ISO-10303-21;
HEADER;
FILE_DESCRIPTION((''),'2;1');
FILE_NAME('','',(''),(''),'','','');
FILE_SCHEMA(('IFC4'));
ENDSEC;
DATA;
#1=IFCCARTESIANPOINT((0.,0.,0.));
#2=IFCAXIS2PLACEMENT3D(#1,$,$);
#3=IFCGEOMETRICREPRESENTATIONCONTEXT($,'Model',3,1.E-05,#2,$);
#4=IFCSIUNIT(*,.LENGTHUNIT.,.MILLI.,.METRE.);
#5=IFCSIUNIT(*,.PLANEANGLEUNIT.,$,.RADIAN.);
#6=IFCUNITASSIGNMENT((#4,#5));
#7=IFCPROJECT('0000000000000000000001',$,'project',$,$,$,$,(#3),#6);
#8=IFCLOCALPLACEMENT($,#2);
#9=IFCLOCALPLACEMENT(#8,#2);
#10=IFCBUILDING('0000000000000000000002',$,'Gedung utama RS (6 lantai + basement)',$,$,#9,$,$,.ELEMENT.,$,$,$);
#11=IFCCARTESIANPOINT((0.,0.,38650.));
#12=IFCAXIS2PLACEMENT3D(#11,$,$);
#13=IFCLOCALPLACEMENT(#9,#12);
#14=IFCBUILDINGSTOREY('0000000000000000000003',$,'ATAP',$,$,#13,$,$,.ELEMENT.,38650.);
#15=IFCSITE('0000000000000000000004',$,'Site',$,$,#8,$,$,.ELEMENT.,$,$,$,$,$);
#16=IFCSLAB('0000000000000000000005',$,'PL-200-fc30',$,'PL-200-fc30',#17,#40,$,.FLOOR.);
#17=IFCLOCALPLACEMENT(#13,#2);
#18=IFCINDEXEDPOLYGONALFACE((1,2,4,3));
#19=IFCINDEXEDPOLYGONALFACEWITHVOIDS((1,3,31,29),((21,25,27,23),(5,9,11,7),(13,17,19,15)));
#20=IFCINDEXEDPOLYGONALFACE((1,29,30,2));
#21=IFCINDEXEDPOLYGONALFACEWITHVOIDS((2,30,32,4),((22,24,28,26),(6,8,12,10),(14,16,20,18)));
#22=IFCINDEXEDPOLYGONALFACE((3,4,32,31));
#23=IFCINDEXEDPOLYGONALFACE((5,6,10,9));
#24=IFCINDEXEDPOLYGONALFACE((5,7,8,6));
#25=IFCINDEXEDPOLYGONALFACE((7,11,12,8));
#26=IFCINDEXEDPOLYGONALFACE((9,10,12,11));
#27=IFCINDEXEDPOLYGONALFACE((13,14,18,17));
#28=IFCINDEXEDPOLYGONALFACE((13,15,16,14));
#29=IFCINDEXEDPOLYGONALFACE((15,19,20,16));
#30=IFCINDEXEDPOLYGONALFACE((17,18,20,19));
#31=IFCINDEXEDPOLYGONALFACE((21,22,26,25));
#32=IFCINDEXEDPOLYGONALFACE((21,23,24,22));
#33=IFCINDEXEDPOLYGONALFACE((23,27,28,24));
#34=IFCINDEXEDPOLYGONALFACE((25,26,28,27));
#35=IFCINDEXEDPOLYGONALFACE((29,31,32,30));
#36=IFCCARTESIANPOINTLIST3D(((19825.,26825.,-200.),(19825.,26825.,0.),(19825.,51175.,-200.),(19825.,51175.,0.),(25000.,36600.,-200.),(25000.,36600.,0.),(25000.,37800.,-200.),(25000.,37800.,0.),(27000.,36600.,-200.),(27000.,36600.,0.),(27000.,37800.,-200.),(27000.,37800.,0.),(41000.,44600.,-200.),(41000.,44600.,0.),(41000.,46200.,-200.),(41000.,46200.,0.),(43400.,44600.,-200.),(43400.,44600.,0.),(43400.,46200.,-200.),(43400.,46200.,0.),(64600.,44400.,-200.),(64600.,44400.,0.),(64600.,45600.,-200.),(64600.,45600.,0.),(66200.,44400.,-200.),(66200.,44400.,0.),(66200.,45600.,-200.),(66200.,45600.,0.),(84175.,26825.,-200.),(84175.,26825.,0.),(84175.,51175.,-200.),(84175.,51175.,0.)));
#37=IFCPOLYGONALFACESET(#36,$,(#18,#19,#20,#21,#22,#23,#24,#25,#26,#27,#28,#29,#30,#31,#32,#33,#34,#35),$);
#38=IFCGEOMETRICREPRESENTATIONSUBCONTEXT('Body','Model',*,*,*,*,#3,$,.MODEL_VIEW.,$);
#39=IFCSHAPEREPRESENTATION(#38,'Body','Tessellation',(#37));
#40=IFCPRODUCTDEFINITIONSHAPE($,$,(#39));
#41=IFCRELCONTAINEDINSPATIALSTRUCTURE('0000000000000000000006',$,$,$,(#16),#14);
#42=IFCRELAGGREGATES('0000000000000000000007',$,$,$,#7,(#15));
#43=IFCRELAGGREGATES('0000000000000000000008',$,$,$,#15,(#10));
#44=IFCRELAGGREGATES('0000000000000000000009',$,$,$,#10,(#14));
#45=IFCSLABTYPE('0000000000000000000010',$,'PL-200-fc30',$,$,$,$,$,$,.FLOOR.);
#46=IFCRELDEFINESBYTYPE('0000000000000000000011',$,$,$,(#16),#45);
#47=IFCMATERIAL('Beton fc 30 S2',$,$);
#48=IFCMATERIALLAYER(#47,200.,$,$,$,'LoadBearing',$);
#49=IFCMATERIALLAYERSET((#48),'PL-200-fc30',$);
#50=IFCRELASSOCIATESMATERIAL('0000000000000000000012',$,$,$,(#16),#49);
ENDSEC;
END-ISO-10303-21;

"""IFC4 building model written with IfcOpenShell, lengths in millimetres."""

from ifc_helpers import new_model, si_unit, frame, origin, place, context, subcontext, project, spatial, polyline, outline, extrude, material, layer, layer_set, layer_usage, type_object, element, save


model = new_model("IFC4")

# Units and contexts
model_context = context("Model", 3, precision=1e-05, world=origin())
body_context = subcontext(model_context, "Body", "Model", "MODEL_VIEW")
ifc_project = project(units=[si_unit("LENGTHUNIT", "METRE", prefix="MILLI"), si_unit("PLANEANGLEUNIT", "RADIAN")], contexts=[model_context])

# Site, building, storey
site_placement = place(None, origin())
site = spatial("IfcSite", under=ifc_project, at=site_placement, Name="Site", CompositionType="ELEMENT")
building_placement = place(site_placement, origin())
building = spatial("IfcBuilding", under=site, at=building_placement, Name="Gedung utama RS (6 lantai + basement)", CompositionType="ELEMENT")
storey_placement = place(building_placement, frame((0.0, 0.0, 38650.0)))
storey = spatial("IfcBuildingStorey", under=building, at=storey_placement, Name="ATAP", CompositionType="ELEMENT", Elevation=38650.0)

# Shared definitions
ifc_material = material(Name="Beton fc 30 S2")

# Slab, openings
ifc_layer = layer(ifc_material, 200.0, Category="LoadBearing")
ifc_layer_set = layer_set([ifc_layer], Name="PL-200-fc30")
ifc_layer_usage = layer_usage(ifc_layer_set, "AXIS3", "NEGATIVE", 0.0)
slab_type = type_object("IfcSlabType", Name="PL-200-fc30", PredefinedType="FLOOR")
slab_placement = place(storey_placement, origin())
slab = element("IfcSlab", 1, at=slab_placement, inside=storey, type_object=slab_type, material=ifc_layer_usage, Name="PL-200-fc30", ObjectType="PL-200-fc30", PredefinedType="FLOOR", context=body_context, shape_type="SweptSolid", body=[
    extrude(outline(polyline([(84175.0, 51175.0), (19825.0, 51175.0), (19825.0, 26825.0), (84175.0, 26825.0), (84175.0, 51175.0)])), frame((0.0, 0.0, -200.0)), (0.0, 0.0, 1.0), 200.0),
])
opening_1_placement = place(slab_placement, frame((0.0, 0.0, -25700.0)))
element("IfcOpeningElement", 2, at=opening_1_placement, cuts=slab, PredefinedType="OPENING", context=body_context, shape_type="SweptSolid", body=[
    extrude(outline(polyline([(27000.0, 36600.0), (27000.0, 37800.0), (25000.0, 37800.0), (25000.0, 36600.0), (27000.0, 36600.0)])), origin(), (0.0, 0.0, 1.0), 25800.0),
])
opening_2_placement = place(slab_placement, frame((0.0, 0.0, -25700.0)))
element("IfcOpeningElement", 3, at=opening_2_placement, cuts=slab, PredefinedType="OPENING", context=body_context, shape_type="SweptSolid", body=[
    extrude(outline(polyline([(43400.0, 44600.0), (43400.0, 46200.0), (41000.0, 46200.0), (41000.0, 44600.0), (43400.0, 44600.0)])), origin(), (0.0, 0.0, 1.0), 25800.0),
])
opening_3_placement = place(slab_placement, frame((0.0, 0.0, -25700.0)))
element("IfcOpeningElement", 4, at=opening_3_placement, cuts=slab, PredefinedType="OPENING", context=body_context, shape_type="SweptSolid", body=[
    extrude(outline(polyline([(66200.0, 44400.0), (66200.0, 45600.0), (64600.0, 45600.0), (64600.0, 44400.0), (66200.0, 44400.0)])), origin(), (0.0, 0.0, 1.0), 25800.0),
])

save(model, "model.ifc")
